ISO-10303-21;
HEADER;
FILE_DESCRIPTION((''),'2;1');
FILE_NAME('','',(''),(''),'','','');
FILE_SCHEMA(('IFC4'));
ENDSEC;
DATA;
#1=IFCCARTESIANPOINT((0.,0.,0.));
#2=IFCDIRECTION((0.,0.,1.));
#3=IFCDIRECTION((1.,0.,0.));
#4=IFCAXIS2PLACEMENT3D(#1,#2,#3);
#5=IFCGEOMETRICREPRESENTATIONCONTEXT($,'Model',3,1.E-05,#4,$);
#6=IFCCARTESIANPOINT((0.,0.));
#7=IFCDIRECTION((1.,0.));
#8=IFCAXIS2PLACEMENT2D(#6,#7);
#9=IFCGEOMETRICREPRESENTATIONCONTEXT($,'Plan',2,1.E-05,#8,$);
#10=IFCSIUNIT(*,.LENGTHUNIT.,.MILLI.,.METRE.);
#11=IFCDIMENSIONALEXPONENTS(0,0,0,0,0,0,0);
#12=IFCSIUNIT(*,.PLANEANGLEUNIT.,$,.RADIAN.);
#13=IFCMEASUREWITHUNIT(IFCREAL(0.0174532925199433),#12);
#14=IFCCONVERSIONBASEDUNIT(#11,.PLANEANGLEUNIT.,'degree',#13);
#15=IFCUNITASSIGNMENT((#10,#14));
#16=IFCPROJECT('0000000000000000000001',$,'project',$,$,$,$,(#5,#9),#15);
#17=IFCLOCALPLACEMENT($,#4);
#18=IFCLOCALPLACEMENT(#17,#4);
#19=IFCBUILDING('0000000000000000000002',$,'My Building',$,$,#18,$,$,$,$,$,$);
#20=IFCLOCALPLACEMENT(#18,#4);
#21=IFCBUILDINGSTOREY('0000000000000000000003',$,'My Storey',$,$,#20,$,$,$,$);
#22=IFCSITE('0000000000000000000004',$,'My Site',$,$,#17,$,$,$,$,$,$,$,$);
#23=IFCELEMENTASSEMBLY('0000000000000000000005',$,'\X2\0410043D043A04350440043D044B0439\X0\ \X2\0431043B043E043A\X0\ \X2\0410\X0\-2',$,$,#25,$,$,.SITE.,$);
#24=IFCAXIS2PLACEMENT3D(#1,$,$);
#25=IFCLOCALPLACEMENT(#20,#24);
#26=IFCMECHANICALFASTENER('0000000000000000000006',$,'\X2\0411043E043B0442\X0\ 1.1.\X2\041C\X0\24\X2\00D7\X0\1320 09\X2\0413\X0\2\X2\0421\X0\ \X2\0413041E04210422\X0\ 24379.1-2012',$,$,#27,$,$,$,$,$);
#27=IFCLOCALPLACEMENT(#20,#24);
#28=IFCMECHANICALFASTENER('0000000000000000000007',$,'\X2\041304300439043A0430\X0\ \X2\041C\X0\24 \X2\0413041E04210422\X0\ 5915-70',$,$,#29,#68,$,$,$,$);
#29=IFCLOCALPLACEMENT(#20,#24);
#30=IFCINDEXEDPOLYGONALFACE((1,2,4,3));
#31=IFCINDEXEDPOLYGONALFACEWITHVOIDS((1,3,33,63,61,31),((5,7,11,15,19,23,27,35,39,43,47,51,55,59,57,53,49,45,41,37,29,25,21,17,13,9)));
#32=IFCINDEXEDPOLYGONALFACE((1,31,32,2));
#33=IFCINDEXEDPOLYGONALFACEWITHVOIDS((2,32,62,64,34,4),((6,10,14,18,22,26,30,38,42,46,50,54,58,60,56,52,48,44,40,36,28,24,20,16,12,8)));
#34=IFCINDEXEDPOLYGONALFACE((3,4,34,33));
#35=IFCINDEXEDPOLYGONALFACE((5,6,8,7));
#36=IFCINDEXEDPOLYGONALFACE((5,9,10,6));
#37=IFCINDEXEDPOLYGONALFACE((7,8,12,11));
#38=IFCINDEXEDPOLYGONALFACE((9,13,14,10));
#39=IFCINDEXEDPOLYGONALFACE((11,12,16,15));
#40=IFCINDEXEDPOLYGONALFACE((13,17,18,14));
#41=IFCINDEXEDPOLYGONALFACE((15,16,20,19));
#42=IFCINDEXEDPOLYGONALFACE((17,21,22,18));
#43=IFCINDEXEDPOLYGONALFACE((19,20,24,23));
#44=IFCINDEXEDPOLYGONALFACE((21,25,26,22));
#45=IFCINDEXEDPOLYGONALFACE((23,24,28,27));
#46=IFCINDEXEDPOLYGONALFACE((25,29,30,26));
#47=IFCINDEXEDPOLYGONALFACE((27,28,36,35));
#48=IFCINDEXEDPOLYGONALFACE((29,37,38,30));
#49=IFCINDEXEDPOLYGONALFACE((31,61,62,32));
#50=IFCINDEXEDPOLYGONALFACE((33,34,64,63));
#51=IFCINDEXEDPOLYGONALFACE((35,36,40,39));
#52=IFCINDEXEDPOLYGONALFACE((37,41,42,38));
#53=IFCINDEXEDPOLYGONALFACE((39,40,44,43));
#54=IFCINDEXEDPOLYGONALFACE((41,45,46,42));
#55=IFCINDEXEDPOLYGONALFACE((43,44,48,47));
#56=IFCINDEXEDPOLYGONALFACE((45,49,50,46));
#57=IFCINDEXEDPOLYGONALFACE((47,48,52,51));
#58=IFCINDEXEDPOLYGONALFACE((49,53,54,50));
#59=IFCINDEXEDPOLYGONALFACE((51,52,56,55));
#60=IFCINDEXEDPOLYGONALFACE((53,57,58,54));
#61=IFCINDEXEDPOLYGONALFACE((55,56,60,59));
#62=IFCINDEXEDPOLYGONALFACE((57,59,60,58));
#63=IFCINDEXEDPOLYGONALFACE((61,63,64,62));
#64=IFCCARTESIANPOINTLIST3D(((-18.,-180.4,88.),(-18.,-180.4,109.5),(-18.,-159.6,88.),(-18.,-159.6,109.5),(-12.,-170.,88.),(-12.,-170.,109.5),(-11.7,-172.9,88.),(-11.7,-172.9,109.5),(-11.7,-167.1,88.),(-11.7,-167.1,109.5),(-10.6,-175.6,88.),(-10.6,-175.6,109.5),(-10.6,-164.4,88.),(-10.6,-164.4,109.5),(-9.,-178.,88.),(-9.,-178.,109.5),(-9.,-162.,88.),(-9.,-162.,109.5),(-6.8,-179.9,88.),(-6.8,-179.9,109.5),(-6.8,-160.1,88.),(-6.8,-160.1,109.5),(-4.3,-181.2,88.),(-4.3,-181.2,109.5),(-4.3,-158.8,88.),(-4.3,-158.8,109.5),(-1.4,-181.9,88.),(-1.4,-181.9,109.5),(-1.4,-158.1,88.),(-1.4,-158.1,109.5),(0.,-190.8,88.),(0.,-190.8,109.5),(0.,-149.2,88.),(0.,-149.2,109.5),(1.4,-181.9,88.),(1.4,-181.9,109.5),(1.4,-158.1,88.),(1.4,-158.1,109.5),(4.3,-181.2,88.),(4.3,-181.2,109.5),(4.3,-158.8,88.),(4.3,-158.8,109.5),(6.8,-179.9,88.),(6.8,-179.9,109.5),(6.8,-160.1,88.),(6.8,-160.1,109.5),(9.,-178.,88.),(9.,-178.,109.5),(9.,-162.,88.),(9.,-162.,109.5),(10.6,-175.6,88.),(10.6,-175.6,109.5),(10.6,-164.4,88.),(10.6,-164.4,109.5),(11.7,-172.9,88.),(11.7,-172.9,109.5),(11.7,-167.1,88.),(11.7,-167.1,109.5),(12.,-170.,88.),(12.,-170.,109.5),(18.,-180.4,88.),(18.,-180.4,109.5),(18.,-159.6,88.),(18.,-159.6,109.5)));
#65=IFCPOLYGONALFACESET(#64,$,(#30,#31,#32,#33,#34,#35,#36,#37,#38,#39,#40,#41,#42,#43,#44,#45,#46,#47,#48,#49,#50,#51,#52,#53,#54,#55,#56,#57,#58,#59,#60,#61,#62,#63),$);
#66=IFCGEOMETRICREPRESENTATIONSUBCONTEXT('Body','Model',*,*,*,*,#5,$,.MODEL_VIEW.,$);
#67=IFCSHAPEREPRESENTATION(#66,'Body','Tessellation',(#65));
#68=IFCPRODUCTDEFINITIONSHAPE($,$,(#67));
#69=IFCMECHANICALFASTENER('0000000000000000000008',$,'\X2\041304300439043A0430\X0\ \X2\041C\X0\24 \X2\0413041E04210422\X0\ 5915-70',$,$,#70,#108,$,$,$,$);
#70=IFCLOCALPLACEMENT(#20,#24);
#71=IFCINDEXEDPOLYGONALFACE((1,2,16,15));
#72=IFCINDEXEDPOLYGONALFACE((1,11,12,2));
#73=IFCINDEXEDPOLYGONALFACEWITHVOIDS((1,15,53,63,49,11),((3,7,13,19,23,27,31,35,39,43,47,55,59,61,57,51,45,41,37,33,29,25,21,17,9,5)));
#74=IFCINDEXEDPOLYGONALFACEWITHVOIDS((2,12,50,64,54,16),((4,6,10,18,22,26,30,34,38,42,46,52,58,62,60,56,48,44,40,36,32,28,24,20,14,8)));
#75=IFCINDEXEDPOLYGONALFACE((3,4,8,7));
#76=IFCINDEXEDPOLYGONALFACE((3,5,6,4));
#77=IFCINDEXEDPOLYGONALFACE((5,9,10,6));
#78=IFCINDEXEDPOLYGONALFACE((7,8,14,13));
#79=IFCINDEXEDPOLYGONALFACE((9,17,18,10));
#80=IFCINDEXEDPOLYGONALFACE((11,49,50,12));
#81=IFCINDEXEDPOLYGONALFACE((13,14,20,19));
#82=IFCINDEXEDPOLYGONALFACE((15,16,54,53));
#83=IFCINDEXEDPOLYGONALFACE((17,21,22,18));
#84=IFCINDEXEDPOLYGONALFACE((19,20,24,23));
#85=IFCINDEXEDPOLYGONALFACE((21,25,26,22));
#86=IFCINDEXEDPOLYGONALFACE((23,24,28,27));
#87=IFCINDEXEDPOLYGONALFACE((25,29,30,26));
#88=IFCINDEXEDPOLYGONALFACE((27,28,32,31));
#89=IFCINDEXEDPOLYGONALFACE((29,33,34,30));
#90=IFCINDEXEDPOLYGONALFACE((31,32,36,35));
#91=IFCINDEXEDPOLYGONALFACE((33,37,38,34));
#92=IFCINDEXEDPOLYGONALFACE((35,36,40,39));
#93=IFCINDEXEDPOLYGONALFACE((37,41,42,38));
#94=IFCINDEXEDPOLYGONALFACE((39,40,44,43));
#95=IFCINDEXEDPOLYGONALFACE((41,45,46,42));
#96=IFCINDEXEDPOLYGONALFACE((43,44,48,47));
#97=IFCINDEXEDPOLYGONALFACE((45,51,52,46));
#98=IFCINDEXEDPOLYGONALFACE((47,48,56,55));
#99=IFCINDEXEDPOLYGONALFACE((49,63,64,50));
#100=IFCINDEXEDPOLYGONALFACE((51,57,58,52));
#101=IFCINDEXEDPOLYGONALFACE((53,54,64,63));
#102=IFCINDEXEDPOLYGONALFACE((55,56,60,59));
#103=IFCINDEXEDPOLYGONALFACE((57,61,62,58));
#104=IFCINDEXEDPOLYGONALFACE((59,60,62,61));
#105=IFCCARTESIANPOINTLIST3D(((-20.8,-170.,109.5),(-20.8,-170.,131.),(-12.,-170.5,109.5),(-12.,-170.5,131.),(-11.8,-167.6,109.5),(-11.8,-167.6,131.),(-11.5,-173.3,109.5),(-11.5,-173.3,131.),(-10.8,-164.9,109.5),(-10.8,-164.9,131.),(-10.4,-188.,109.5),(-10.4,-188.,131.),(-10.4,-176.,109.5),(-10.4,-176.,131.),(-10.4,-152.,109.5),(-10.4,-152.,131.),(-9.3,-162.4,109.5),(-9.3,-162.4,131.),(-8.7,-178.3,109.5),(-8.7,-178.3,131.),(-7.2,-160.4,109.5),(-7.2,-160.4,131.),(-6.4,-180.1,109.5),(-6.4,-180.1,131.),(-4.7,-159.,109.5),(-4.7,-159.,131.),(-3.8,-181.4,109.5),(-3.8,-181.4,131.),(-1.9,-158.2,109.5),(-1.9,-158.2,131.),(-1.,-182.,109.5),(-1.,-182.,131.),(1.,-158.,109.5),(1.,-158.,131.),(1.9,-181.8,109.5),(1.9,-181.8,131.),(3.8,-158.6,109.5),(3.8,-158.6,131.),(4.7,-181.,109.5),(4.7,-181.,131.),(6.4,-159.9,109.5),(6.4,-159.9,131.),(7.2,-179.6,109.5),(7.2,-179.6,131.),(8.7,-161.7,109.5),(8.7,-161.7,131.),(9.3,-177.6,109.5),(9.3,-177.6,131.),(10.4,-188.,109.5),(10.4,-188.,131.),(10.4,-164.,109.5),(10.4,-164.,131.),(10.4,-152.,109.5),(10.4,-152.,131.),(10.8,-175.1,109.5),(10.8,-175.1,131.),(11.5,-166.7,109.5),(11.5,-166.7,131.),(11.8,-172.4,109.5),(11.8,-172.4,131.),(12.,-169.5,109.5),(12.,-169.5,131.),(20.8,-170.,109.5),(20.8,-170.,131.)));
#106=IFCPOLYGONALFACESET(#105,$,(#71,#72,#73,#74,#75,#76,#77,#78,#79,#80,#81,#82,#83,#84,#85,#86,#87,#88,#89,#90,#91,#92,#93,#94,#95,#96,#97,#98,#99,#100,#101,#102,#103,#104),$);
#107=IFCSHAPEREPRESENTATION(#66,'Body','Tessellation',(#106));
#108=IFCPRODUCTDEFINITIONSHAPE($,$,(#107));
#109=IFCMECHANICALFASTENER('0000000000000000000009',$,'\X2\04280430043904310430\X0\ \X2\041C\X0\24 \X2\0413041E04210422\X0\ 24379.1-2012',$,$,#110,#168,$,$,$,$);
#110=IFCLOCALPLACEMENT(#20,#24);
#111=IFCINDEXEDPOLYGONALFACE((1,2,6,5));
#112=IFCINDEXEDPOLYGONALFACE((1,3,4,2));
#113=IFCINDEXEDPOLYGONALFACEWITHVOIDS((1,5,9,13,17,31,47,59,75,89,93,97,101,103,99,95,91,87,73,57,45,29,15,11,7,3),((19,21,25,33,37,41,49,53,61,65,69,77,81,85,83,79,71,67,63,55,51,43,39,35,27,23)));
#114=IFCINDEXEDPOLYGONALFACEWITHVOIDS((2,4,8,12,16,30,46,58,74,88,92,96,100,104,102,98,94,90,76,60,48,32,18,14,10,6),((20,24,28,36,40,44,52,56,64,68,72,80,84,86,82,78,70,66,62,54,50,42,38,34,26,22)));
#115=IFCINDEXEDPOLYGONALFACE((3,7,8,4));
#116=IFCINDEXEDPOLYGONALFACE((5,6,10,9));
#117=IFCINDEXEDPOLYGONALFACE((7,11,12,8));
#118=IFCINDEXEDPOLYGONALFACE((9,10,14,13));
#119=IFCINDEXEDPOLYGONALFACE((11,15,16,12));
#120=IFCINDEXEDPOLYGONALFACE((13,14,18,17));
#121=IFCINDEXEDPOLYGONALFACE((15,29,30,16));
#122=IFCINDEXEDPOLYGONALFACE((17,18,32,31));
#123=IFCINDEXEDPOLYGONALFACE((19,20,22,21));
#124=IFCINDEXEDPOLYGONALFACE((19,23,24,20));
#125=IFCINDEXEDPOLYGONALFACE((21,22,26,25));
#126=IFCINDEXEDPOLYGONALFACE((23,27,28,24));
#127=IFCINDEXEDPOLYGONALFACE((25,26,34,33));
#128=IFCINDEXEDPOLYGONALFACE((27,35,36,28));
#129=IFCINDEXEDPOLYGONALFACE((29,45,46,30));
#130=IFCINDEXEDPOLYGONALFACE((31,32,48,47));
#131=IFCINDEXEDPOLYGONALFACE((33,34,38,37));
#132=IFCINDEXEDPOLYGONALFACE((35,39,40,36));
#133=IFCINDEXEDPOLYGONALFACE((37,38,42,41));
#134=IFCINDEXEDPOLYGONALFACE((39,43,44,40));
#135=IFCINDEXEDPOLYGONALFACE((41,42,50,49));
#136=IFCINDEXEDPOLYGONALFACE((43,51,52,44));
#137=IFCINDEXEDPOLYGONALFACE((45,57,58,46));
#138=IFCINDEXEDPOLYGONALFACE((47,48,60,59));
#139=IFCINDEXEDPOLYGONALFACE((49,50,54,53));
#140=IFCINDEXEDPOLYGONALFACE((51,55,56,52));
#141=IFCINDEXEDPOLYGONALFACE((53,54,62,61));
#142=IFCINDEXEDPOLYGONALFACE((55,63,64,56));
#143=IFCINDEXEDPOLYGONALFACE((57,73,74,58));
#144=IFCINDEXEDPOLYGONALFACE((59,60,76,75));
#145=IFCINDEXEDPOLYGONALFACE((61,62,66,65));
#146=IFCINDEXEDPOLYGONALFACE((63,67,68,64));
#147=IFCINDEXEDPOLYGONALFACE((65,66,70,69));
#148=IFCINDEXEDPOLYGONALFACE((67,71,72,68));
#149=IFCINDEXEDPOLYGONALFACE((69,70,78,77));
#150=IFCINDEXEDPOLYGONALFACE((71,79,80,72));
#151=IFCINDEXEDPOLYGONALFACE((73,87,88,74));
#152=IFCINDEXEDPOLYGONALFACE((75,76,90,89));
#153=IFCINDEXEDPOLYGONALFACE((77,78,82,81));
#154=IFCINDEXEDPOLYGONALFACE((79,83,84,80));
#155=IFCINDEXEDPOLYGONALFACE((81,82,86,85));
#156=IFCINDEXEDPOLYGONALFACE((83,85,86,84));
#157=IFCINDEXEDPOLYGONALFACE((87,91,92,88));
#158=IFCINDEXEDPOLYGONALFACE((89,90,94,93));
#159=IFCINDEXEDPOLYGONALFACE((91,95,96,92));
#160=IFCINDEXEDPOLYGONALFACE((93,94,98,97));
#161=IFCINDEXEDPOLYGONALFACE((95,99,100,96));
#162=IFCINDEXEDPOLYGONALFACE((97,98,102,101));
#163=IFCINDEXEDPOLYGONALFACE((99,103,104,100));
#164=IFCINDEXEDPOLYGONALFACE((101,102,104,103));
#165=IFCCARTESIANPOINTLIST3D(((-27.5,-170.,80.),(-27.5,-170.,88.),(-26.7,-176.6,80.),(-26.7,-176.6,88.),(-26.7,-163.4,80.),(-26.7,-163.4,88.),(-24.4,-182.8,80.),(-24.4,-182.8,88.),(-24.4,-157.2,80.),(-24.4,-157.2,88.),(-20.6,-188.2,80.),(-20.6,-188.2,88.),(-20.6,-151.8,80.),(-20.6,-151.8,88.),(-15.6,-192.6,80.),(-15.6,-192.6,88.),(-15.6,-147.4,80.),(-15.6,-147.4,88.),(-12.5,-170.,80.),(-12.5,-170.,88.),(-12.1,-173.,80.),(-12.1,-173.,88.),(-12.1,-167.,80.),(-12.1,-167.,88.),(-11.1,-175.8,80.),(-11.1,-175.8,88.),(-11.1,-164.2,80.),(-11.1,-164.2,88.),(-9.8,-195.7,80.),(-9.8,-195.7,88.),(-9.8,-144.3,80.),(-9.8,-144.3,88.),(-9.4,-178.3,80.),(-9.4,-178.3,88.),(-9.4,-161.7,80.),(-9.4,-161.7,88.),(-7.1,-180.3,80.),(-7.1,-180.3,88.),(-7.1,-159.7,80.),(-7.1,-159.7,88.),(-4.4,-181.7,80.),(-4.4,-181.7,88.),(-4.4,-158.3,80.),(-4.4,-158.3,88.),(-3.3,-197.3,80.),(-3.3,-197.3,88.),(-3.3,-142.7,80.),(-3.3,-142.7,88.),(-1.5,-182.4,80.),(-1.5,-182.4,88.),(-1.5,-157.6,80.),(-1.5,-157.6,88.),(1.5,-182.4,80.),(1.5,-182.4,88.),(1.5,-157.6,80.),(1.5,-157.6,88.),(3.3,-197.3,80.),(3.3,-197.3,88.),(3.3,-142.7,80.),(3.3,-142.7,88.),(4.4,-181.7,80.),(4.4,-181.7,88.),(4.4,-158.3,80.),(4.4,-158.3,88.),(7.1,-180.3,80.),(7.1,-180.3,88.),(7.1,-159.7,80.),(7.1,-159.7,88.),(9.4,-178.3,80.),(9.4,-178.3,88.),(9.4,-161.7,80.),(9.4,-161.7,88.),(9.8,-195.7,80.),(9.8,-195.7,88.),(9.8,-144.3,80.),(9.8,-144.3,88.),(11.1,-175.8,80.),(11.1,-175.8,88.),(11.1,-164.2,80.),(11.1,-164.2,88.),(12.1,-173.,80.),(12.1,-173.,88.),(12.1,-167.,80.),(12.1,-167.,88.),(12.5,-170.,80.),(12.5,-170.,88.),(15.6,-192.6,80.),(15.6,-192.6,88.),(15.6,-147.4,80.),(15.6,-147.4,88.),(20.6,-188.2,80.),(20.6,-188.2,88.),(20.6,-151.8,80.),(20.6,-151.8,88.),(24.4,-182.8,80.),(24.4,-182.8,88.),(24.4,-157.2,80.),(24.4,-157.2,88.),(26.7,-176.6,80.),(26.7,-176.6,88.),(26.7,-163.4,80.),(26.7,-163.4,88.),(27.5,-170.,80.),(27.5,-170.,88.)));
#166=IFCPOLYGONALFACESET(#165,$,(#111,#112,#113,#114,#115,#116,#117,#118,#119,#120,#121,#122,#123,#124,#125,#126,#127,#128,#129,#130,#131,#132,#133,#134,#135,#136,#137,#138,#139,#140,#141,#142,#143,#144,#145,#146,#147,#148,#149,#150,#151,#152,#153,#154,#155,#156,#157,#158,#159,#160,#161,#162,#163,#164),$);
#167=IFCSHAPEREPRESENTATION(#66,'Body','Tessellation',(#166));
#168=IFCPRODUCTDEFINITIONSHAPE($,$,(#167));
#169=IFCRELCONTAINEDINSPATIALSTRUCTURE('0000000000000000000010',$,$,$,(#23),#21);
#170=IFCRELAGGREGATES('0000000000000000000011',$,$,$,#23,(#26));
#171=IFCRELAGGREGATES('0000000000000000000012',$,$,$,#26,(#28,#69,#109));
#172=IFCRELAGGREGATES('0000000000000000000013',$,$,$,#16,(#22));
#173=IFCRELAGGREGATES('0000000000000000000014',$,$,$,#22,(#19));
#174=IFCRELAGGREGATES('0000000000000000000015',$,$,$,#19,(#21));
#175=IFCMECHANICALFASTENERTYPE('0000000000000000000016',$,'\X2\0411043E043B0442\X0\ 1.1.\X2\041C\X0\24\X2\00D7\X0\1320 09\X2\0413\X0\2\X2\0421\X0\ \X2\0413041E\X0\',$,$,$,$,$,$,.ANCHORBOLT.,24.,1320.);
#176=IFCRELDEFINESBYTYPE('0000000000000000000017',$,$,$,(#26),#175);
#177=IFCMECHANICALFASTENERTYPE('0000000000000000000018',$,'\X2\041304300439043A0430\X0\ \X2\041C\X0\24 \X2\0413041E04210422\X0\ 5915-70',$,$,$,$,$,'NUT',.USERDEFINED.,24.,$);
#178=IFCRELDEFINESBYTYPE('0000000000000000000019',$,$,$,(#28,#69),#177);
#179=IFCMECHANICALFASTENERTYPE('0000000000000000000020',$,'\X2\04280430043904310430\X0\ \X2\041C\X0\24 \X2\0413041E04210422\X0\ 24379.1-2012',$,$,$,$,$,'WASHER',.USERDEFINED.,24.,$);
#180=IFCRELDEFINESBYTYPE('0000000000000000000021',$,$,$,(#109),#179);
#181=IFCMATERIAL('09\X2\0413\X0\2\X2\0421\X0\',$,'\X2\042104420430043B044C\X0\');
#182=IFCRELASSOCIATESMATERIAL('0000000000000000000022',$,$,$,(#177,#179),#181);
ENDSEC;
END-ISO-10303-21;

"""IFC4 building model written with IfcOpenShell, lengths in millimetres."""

from ifc_helpers import new_model, entity, si_unit, converted_unit, frame, origin_with_axes, origin_2d_with_axis, place, context, subcontext, project, spatial, polyline, outline, extrude, source, transform, mapped, material, type_object, type_shapes, element, aggregate, save


model = new_model("IFC4")

# Units and contexts
model_context = context("Model", 3, precision=1e-05, world=origin_with_axes())
plan_context = context("Plan", 2, precision=1e-05, world=origin_2d_with_axis())
body_context = subcontext(model_context, "Body", "Model", "MODEL_VIEW")
ifc_project = project(units=[si_unit("LENGTHUNIT", "METRE", prefix="MILLI"), converted_unit("PLANEANGLEUNIT", "degree", entity("IfcReal", 0.0174532925199433), si_unit("PLANEANGLEUNIT", "RADIAN"), dimensions=[0, 0, 0, 0, 0, 0, 0])], contexts=[model_context, plan_context])

# Site, building, storey
site_placement = place(None, origin_with_axes())
site = spatial("IfcSite", under=ifc_project, at=site_placement, Name="My Site")
building_placement = place(site_placement, origin_with_axes())
building = spatial("IfcBuilding", under=site, at=building_placement, Name="My Building")
storey_placement = place(building_placement, origin_with_axes())
storey = spatial("IfcBuildingStorey", under=building, at=storey_placement, Name="My Storey")

# Shared definitions
placement = place(storey_placement, origin_with_axes())

# Element assembly, mechanical fasteners
assembly = element("IfcElementAssembly", 1, at=placement, inside=storey, Name="Анкерный блок А-2", AssemblyPlace="SITE")
mechanical_fastener_type_1 = type_object("IfcMechanicalFastenerType", Name="Болт 1.1.М24×1320 09Г2С ГО", NominalDiameter=24.0, NominalLength=1320.0, PredefinedType="ANCHORBOLT")
mechanical_fastener_1_placement = place(placement, frame((0.0, -170.0, 0.0), z_axis=(0.0, 0.0, 1.0), x_axis=(1.0, 0.0, 0.0)))
mechanical_fastener_1 = element("IfcMechanicalFastener", 2, at=mechanical_fastener_1_placement, type_object=mechanical_fastener_type_1, Name="Болт 1.1.М24×1320 09Г2С ГОСТ 24379.1-2012")
aggregate(assembly, [mechanical_fastener_1])
ifc_material_1 = material(Name="09Г2С", Category="Сталь")
mechanical_fastener_type_2 = type_object("IfcMechanicalFastenerType", Name="Гайка М24 ГОСТ 5915-70", ElementType="NUT", NominalDiameter=24.0, PredefinedType="USERDEFINED", material=ifc_material_1)
shared_shape_1 = source(origin_with_axes(), body_context, "Body", "SweptSolid", [
    extrude(outline(polyline([(-10.4, -18.0), (10.4, -18.0), (20.8, 0.0), (10.4, 18.0), (-10.4, 18.0), (-20.8, 0.0), (-10.4, -18.0)]), holes=[polyline([(-8.0, 9.0), (-5.6, 10.6), (-2.9, 11.7), (0.0, 12.0), (2.9, 11.7), (5.6, 10.6), (8.0, 9.0), (9.9, 6.8), (11.2, 4.3), (11.9, 1.4), (11.9, -1.4), (11.2, -4.3), (9.9, -6.8), (8.0, -9.0), (5.6, -10.6), (2.9, -11.7), (0.0, -12.0), (-2.9, -11.7), (-5.6, -10.6), (-8.0, -9.0), (-9.9, -6.8), (-11.2, -4.3), (-11.9, -1.4), (-11.9, 1.4), (-11.2, 4.3), (-9.9, 6.8), (-8.0, 9.0)])]), frame((0.0, 0.0, 0.0), z_axis=(0.0, 0.0, 1.0), x_axis=(0.0, 1.0, 0.0)), (0.0, 0.0, 1.0), 21.5),
])
type_shapes(mechanical_fastener_type_2, [shared_shape_1])
mechanical_fastener_2_placement = place(mechanical_fastener_1_placement, frame((0.0, 0.0, 88.0), z_axis=(0.0, 0.0, 1.0), x_axis=(1.0, 0.0, 0.0)))
mechanical_fastener_2 = element("IfcMechanicalFastener", 3, at=mechanical_fastener_2_placement, type_object=mechanical_fastener_type_2, Name="Гайка М24 ГОСТ 5915-70", context=body_context, shape_type="MappedRepresentation", body=[
    mapped(shared_shape_1, transform((0.0, 0.0, 0.0), x_axis=(1.0, 0.0, 0.0), y_axis=(0.0, 1.0, 0.0), z_axis=(0.0, 0.0, 1.0), scale=1.0)),
])
mechanical_fastener_3_placement = place(mechanical_fastener_1_placement, frame((0.0, 0.0, 109.5), z_axis=(0.0, 0.0, 1.0), x_axis=(0.866025, 0.5, 0.0)))
mechanical_fastener_3 = element("IfcMechanicalFastener", 4, at=mechanical_fastener_3_placement, type_object=mechanical_fastener_type_2, Name="Гайка М24 ГОСТ 5915-70", context=body_context, shape_type="MappedRepresentation", body=[
    mapped(shared_shape_1, transform((0.0, 0.0, 0.0), x_axis=(1.0, 0.0, 0.0), y_axis=(0.0, 1.0, 0.0), z_axis=(0.0, 0.0, 1.0), scale=1.0)),
])
mechanical_fastener_type_3 = type_object("IfcMechanicalFastenerType", Name="Шайба М24 ГОСТ 24379.1-2012", ElementType="WASHER", NominalDiameter=24.0, PredefinedType="USERDEFINED", material=ifc_material_1)
shared_shape_2 = source(origin_with_axes(), body_context, "Body", "SweptSolid", [
    extrude(outline(polyline([(27.5, 0.0), (26.7, 6.6), (24.4, 12.8), (20.6, 18.2), (15.6, 22.6), (9.8, 25.7), (3.3, 27.3), (-3.3, 27.3), (-9.8, 25.7), (-15.6, 22.6), (-20.6, 18.2), (-24.4, 12.8), (-26.7, 6.6), (-27.5, 0.0), (-26.7, -6.6), (-24.4, -12.8), (-20.6, -18.2), (-15.6, -22.6), (-9.8, -25.7), (-3.3, -27.3), (3.3, -27.3), (9.8, -25.7), (15.6, -22.6), (20.6, -18.2), (24.4, -12.8), (26.7, -6.6), (27.5, 0.0)]), holes=[polyline([(-4.4, -11.7), (-7.1, -10.3), (-9.4, -8.3), (-11.1, -5.8), (-12.1, -3.0), (-12.5, 0.0), (-12.1, 3.0), (-11.1, 5.8), (-9.4, 8.3), (-7.1, 10.3), (-4.4, 11.7), (-1.5, 12.4), (1.5, 12.4), (4.4, 11.7), (7.1, 10.3), (9.4, 8.3), (11.1, 5.8), (12.1, 3.0), (12.5, 0.0), (12.1, -3.0), (11.1, -5.8), (9.4, -8.3), (7.1, -10.3), (4.4, -11.7), (1.5, -12.4), (-1.5, -12.4), (-4.4, -11.7)])]), frame((0.0, 0.0, 0.0), z_axis=(0.0, 0.0, 1.0), x_axis=(0.120537, -0.992709, 0.0)), (0.0, 0.0, 1.0), 8.0),
])
type_shapes(mechanical_fastener_type_3, [shared_shape_2])
mechanical_fastener_4_placement = place(mechanical_fastener_1_placement, frame((0.0, 0.0, 80.0), z_axis=(0.0, 0.0, 1.0), x_axis=(1.0, 0.0, 0.0)))
mechanical_fastener_4 = element("IfcMechanicalFastener", 5, at=mechanical_fastener_4_placement, type_object=mechanical_fastener_type_3, Name="Шайба М24 ГОСТ 24379.1-2012", context=body_context, shape_type="MappedRepresentation", body=[
    mapped(shared_shape_2, transform((0.0, 0.0, 0.0), x_axis=(1.0, 0.0, 0.0), y_axis=(0.0, 1.0, 0.0), z_axis=(0.0, 0.0, 1.0), scale=1.0)),
])
aggregate(mechanical_fastener_1, [mechanical_fastener_2, mechanical_fastener_3, mechanical_fastener_4])

save(model, "model.ifc")
